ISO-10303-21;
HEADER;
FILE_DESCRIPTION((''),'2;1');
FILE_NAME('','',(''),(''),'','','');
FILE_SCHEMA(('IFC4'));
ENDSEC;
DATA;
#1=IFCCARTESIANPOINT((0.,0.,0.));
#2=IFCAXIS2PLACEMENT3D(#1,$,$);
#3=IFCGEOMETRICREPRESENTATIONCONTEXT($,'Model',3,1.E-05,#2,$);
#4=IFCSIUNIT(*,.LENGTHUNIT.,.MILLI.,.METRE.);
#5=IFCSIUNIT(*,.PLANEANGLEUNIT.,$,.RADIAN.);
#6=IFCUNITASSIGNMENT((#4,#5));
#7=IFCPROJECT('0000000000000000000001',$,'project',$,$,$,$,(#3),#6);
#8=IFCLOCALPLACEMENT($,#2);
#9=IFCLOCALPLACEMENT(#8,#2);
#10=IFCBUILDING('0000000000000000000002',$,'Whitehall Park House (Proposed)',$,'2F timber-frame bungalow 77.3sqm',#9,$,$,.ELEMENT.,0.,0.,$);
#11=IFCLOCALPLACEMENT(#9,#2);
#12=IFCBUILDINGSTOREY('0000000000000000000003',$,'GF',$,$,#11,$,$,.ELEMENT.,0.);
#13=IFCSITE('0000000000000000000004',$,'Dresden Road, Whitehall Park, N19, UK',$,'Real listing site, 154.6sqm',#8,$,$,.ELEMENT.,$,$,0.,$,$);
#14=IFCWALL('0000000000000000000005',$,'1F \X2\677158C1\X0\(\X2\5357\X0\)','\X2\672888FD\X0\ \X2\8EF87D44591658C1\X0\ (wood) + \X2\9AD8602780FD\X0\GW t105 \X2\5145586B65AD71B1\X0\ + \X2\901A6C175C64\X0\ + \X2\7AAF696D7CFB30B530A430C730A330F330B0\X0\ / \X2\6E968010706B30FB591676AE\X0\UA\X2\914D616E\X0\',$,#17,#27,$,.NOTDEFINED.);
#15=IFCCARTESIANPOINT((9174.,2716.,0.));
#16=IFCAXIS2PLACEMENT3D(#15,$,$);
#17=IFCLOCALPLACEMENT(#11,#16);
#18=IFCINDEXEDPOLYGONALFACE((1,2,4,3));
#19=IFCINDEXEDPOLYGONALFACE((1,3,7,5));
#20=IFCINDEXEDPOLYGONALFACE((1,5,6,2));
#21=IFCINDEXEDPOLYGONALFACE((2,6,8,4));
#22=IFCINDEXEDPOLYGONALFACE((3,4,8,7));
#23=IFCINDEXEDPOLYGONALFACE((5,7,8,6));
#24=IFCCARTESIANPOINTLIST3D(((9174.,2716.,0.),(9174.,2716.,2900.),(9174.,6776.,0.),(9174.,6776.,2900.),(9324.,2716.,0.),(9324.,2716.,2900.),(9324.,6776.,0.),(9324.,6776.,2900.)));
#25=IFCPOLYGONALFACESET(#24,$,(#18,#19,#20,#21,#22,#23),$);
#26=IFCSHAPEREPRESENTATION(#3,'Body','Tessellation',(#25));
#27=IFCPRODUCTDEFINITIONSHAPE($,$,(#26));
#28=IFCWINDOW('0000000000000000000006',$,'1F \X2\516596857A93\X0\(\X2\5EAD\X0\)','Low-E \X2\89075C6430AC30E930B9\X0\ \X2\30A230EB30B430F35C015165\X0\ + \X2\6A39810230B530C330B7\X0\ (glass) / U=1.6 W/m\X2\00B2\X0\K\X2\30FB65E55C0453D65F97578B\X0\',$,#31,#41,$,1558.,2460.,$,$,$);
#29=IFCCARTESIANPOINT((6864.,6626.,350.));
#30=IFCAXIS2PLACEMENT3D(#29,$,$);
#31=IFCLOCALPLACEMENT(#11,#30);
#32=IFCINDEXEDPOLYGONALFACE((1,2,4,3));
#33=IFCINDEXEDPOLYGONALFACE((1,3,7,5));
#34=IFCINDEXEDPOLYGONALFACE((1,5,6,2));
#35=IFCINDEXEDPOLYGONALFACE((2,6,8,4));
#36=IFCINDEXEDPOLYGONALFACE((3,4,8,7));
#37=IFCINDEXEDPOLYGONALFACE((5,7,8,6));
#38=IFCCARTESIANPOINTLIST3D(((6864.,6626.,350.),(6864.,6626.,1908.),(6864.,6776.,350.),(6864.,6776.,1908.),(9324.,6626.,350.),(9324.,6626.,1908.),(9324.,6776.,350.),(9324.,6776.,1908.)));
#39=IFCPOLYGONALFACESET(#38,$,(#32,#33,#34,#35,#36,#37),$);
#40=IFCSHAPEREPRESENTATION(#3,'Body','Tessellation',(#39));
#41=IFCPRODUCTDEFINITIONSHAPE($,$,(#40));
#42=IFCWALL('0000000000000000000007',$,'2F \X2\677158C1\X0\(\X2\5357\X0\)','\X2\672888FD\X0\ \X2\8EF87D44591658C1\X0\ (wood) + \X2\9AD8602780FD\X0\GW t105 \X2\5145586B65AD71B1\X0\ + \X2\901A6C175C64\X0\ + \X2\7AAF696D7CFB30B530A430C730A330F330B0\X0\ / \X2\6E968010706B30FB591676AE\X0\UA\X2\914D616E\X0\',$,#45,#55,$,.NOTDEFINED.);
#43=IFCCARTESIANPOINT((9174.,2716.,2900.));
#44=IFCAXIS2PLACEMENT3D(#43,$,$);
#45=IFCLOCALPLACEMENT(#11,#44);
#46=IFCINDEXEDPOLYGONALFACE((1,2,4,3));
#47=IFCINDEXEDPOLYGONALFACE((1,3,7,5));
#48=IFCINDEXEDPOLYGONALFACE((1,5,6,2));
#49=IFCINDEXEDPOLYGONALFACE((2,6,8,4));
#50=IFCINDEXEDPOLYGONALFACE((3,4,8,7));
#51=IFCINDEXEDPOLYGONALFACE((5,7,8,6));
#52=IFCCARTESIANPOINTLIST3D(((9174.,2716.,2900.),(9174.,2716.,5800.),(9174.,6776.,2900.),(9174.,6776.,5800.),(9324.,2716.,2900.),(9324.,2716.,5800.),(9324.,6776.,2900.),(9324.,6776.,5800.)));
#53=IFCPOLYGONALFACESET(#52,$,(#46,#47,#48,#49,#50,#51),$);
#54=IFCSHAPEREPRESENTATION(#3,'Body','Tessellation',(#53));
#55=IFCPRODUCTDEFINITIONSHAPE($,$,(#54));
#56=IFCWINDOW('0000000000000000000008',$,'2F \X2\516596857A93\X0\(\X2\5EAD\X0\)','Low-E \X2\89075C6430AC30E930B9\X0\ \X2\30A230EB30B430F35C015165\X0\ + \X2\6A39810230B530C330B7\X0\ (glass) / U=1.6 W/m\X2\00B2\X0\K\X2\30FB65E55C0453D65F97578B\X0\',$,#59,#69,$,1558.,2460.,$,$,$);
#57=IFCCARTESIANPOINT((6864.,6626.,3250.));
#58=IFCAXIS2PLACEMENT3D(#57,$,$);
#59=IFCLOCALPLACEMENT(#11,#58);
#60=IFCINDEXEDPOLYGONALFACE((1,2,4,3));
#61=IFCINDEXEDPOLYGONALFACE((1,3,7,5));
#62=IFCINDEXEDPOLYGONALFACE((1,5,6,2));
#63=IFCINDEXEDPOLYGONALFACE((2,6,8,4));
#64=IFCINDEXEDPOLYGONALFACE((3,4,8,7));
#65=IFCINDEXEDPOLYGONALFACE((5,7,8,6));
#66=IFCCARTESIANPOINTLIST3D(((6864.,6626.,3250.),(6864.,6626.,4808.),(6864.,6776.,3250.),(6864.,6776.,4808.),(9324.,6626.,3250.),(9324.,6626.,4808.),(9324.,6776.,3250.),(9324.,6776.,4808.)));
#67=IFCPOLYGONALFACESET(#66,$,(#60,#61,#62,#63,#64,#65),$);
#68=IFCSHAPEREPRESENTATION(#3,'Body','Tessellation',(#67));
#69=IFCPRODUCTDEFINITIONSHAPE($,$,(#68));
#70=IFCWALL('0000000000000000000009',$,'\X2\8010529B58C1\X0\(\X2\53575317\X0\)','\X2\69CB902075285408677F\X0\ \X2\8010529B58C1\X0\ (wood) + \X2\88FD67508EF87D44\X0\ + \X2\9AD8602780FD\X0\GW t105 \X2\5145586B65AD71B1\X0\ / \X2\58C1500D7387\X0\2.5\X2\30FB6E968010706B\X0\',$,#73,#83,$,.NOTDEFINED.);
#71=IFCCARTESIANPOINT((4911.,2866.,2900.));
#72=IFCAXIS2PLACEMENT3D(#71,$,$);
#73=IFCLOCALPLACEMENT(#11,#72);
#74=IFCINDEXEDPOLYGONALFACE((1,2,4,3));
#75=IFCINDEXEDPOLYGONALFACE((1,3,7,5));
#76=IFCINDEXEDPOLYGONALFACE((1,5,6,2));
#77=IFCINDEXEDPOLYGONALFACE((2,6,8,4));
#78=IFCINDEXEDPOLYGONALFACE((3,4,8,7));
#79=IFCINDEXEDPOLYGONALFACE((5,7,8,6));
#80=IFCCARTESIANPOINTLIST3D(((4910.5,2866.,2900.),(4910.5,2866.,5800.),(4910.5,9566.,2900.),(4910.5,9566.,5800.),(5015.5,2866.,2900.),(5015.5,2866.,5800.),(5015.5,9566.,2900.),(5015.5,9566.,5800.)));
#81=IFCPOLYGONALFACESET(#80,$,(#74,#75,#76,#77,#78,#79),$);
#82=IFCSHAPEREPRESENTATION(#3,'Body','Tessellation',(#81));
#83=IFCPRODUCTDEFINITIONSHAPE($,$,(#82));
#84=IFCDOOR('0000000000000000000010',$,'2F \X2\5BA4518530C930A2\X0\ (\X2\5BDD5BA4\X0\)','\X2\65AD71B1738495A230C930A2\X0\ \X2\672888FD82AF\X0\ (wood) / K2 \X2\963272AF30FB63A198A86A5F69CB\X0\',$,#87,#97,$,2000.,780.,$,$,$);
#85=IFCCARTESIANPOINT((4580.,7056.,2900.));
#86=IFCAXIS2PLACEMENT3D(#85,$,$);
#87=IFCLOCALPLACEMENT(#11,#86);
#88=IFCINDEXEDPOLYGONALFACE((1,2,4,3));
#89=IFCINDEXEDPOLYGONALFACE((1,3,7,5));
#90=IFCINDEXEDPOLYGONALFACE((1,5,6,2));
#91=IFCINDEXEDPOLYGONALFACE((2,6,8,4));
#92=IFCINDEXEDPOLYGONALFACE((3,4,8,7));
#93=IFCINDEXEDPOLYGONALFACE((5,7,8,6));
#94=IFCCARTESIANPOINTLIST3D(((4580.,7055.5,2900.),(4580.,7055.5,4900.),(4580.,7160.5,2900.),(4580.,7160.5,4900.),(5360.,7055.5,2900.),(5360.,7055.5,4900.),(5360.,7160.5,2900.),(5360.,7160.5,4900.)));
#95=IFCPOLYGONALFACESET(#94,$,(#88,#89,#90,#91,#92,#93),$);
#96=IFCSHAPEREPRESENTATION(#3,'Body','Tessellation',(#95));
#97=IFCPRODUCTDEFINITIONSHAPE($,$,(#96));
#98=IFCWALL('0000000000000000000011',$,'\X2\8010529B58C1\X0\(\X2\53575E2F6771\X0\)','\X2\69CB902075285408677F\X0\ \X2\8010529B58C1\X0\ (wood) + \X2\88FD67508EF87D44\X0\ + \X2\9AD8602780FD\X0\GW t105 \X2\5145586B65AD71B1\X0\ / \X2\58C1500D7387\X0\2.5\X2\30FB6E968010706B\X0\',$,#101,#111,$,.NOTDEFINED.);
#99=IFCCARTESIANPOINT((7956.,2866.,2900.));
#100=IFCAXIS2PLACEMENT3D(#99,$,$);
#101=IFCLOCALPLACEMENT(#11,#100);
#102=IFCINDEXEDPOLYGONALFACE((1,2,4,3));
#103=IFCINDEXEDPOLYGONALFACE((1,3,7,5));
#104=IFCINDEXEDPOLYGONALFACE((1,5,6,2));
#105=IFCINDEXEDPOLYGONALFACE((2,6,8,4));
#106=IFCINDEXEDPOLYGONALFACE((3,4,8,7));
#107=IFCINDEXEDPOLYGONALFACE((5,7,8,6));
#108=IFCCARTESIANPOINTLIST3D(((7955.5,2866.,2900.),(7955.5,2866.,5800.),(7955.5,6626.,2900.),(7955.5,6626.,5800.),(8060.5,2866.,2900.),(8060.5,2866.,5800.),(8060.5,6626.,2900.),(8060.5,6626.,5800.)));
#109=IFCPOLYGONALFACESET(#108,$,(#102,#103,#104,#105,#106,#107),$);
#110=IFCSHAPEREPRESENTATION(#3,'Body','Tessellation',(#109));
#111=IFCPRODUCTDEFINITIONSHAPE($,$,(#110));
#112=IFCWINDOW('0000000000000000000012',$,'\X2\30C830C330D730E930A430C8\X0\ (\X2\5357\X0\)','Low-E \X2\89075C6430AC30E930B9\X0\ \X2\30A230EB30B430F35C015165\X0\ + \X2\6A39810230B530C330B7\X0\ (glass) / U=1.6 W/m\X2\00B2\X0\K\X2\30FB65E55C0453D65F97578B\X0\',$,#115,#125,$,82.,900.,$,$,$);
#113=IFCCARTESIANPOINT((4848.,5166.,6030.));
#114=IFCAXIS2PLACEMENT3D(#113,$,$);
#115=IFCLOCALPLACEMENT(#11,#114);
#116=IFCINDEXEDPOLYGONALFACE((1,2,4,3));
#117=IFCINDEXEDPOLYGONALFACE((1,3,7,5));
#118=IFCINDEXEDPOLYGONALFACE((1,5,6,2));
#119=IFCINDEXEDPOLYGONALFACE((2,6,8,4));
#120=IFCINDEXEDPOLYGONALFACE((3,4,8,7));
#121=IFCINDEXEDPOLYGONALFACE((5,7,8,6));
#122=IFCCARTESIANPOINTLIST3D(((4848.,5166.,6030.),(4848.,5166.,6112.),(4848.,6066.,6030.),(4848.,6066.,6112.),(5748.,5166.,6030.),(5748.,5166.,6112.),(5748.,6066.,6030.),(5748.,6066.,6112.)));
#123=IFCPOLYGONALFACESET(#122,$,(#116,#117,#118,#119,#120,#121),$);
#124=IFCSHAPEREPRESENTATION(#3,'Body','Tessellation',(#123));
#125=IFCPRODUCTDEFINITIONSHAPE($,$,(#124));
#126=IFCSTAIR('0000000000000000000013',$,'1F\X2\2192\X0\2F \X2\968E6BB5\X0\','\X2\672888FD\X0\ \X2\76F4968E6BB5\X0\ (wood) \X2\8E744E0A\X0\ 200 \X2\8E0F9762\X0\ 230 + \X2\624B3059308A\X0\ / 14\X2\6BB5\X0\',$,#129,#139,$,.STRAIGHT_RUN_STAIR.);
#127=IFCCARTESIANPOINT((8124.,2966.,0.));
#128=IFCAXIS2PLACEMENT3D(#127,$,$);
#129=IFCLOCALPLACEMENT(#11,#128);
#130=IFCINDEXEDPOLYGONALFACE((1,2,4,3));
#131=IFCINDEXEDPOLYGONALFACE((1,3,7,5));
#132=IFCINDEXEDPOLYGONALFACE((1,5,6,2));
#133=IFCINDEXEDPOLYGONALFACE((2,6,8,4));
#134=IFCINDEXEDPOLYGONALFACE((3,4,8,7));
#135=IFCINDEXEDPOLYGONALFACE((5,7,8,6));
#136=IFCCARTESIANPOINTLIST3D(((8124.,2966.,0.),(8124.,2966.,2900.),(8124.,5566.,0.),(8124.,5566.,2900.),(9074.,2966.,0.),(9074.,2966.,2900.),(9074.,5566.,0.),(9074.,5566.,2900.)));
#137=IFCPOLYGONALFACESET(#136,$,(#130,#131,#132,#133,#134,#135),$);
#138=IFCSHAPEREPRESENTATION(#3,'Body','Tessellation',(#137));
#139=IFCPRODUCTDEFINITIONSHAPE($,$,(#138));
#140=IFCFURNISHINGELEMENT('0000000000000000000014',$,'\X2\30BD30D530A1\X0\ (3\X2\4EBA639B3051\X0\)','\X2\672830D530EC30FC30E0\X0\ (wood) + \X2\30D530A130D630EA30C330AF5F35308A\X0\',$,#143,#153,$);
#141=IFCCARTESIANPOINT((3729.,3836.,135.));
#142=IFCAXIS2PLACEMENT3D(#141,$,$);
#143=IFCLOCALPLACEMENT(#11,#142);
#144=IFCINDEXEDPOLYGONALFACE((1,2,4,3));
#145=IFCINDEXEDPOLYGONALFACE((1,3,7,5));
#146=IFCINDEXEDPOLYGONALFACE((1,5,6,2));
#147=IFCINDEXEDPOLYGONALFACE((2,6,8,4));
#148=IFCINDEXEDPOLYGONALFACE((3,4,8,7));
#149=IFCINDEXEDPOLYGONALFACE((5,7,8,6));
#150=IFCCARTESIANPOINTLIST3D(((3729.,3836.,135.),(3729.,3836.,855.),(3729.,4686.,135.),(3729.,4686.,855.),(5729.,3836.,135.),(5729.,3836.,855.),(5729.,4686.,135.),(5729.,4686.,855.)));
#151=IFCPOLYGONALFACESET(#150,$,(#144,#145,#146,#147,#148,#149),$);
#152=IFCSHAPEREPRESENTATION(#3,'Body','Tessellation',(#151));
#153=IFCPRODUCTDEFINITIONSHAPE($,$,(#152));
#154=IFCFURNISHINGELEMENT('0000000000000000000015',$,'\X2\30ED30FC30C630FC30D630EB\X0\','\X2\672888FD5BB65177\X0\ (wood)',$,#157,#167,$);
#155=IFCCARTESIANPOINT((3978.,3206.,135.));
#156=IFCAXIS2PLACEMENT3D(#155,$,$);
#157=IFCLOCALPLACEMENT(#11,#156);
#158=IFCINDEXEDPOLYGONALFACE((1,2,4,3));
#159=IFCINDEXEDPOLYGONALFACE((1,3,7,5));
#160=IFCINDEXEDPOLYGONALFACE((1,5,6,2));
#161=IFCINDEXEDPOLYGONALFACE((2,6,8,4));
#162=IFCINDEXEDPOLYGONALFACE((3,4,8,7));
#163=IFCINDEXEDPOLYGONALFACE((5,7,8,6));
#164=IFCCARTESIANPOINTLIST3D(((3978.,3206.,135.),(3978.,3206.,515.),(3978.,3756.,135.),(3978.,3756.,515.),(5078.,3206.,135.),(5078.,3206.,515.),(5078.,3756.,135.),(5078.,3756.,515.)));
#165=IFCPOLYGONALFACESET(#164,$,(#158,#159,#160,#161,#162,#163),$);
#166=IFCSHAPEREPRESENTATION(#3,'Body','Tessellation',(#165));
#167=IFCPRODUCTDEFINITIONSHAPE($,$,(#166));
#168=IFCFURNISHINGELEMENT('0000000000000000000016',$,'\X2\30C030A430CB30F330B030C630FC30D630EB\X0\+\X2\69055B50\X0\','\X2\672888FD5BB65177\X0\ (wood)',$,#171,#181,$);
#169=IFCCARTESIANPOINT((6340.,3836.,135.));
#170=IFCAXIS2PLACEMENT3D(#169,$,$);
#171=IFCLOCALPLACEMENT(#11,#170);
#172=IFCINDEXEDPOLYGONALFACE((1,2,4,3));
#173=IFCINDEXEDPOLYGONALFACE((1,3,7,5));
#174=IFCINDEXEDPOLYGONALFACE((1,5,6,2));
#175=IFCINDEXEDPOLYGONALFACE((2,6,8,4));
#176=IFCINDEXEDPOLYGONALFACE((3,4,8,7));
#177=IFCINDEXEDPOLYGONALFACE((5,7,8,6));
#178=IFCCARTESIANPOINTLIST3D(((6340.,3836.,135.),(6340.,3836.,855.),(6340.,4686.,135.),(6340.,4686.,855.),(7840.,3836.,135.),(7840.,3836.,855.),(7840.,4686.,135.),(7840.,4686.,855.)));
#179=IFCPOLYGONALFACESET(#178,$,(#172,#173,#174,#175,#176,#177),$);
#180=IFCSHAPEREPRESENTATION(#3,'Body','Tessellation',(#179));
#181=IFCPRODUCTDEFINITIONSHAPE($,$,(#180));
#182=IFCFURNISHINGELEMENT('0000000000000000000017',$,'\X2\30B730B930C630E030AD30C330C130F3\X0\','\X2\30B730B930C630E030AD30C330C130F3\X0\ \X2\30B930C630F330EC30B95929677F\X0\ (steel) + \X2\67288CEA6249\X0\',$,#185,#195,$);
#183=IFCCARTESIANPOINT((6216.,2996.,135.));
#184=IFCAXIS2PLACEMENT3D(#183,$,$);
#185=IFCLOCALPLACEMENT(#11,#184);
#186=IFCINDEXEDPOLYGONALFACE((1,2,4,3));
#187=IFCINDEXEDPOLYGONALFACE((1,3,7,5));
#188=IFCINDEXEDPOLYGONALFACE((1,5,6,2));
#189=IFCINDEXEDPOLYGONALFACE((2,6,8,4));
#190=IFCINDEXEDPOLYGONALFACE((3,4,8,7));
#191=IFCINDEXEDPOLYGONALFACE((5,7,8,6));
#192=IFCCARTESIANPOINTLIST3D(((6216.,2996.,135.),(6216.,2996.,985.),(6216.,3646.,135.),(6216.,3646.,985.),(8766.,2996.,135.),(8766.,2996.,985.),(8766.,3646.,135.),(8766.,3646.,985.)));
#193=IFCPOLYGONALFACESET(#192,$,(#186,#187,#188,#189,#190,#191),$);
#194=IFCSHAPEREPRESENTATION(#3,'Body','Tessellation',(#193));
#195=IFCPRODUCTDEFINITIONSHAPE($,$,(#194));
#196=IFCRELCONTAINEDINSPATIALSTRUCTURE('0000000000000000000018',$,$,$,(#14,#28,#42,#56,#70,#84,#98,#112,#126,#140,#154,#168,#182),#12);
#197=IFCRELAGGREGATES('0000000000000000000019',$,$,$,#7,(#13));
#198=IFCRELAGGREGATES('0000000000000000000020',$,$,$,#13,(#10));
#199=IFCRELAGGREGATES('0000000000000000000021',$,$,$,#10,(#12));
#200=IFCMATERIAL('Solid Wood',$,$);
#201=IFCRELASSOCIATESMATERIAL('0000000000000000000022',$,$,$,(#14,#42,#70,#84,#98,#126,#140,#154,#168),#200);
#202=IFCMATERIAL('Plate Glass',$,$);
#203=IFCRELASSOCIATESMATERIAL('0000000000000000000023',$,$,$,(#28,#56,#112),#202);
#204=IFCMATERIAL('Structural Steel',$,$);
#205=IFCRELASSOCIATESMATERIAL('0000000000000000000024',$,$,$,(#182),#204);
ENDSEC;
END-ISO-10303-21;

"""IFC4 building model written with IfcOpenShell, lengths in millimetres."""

from ifc_helpers import new_model, si_unit, frame, frame_2d, origin, place, context, project, spatial, rectangle, extrude, material, element, fill, save


model = new_model("IFC4")

# Units and contexts
model_context = context("Model", 3, precision=1e-05, world=origin())
ifc_project = project(units=[si_unit("LENGTHUNIT", "METRE", prefix="MILLI"), si_unit("PLANEANGLEUNIT", "RADIAN")], contexts=[model_context])

# Site, building, storey
site_placement = place(None, origin())
site = spatial("IfcSite", under=ifc_project, at=site_placement, Name="Dresden Road, Whitehall Park, N19, UK", ObjectType="Real listing site, 154.6sqm", CompositionType="ELEMENT", RefElevation=0.0)
building_placement = place(site_placement, origin())
building = spatial("IfcBuilding", under=site, at=building_placement, Name="Whitehall Park House (Proposed)", ObjectType="2F timber-frame bungalow 77.3sqm", CompositionType="ELEMENT", ElevationOfRefHeight=0.0, ElevationOfTerrain=0.0)
storey_placement = place(building_placement, origin())
storey = spatial("IfcBuildingStorey", under=building, at=storey_placement, Name="GF", CompositionType="ELEMENT", Elevation=0.0)

# Wall, opening, window
ifc_material_1 = material(Name="Solid Wood")
wall_1_placement = place(storey_placement, frame((9174.0, 2716.0, 0.0)))
wall_1 = element("IfcWall", 1, at=wall_1_placement, inside=storey, material=ifc_material_1, Name="1F 東壁(南)", Description="木製 軸組外壁 (wood) + 高性能GW t105 充填断熱 + 通気層 + 窯業系サイディング / 準耐火・外皮UA配慮", PredefinedType="NOTDEFINED", context=model_context, shape_type="SweptSolid", body=[
    extrude(rectangle(XDim=150.0, YDim=4060.0, at=frame_2d((75.0, 2030.0))), frame((9174.0, 2716.0, 0.0)), (0.0, 0.0, 1.0), 2900.0),
])
opening_1_placement = place(storey_placement, frame((6864.0, 6626.0, 350.0)))
opening_1 = element("IfcOpeningElement", 2, at=opening_1_placement, cuts=wall_1, PredefinedType="NOTDEFINED", context=model_context, shape_type="SweptSolid", body=[
    extrude(rectangle(XDim=2460.0, YDim=150.0, at=frame_2d((1230.0, 75.0))), frame((6864.0, 6626.0, 350.0)), (0.0, 0.0, 1.0), 1558.0),
])
ifc_material_2 = material(Name="Plate Glass")
window_1_placement = place(storey_placement, frame((6864.0, 6626.0, 350.0)))
window_1 = element("IfcWindow", 3, at=window_1_placement, inside=storey, material=ifc_material_2, Name="1F 入隅窓(庭)", Description="Low-E 複層ガラス アルゴン封入 + 樹脂サッシ (glass) / U=1.6 W/m²K・日射取得型", OverallHeight=1558.0, OverallWidth=2460.0, context=model_context, shape_type="SweptSolid", body=[
    extrude(rectangle(XDim=2460.0, YDim=150.0, at=frame_2d((1230.0, 75.0))), frame((6864.0, 6626.0, 350.0)), (0.0, 0.0, 1.0), 1558.0),
])
fill(opening_1, window_1)

# Wall, opening, window
wall_2_placement = place(storey_placement, frame((9174.0, 2716.0, 2900.0)))
wall_2 = element("IfcWall", 4, at=wall_2_placement, inside=storey, material=ifc_material_1, Name="2F 東壁(南)", Description="木製 軸組外壁 (wood) + 高性能GW t105 充填断熱 + 通気層 + 窯業系サイディング / 準耐火・外皮UA配慮", PredefinedType="NOTDEFINED", context=model_context, shape_type="SweptSolid", body=[
    extrude(rectangle(XDim=150.0, YDim=4060.0, at=frame_2d((75.0, 2030.0))), frame((9174.0, 2716.0, 2900.0)), (0.0, 0.0, 1.0), 2900.0),
])
opening_2_placement = place(storey_placement, frame((6864.0, 6626.0, 3250.0)))
opening_2 = element("IfcOpeningElement", 5, at=opening_2_placement, cuts=wall_2, PredefinedType="NOTDEFINED", context=model_context, shape_type="SweptSolid", body=[
    extrude(rectangle(XDim=2460.0, YDim=150.0, at=frame_2d((1230.0, 75.0))), frame((6864.0, 6626.0, 3250.0)), (0.0, 0.0, 1.0), 1558.0),
])
window_2_placement = place(storey_placement, frame((6864.0, 6626.0, 3250.0)))
window_2 = element("IfcWindow", 6, at=window_2_placement, inside=storey, material=ifc_material_2, Name="2F 入隅窓(庭)", Description="Low-E 複層ガラス アルゴン封入 + 樹脂サッシ (glass) / U=1.6 W/m²K・日射取得型", OverallHeight=1558.0, OverallWidth=2460.0, context=model_context, shape_type="SweptSolid", body=[
    extrude(rectangle(XDim=2460.0, YDim=150.0, at=frame_2d((1230.0, 75.0))), frame((6864.0, 6626.0, 3250.0)), (0.0, 0.0, 1.0), 1558.0),
])
fill(opening_2, window_2)

# Wall, opening, door
wall_3_placement = place(storey_placement, frame((4911.0, 2866.0, 2900.0)))
wall_3 = element("IfcWall", 7, at=wall_3_placement, inside=storey, material=ifc_material_1, Name="耐力壁(南北)", Description="構造用合板 耐力壁 (wood) + 製材軸組 + 高性能GW t105 充填断熱 / 壁倍率2.5・準耐火", PredefinedType="NOTDEFINED", context=model_context, shape_type="SweptSolid", body=[
    extrude(rectangle(XDim=105.0, YDim=6700.0, at=frame_2d((52.0, 3350.0))), frame((4911.0, 2866.0, 2900.0)), (0.0, 0.0, 1.0), 2900.0),
])
opening_3_placement = place(storey_placement, frame((4580.0, 7056.0, 2900.0)))
opening_3 = element("IfcOpeningElement", 8, at=opening_3_placement, cuts=wall_3, PredefinedType="NOTDEFINED", context=model_context, shape_type="SweptSolid", body=[
    extrude(rectangle(XDim=780.0, YDim=105.0, at=frame_2d((390.0, 52.0))), frame((4580.0, 7056.0, 2900.0)), (0.0, 0.0, 1.0), 2000.0),
])
door_1_placement = place(storey_placement, frame((4580.0, 7056.0, 2900.0)))
door_1 = element("IfcDoor", 9, at=door_1_placement, inside=storey, material=ifc_material_1, Name="2F 室内ドア (寝室)", Description="断熱玄関ドア 木製芯 (wood) / K2 防犯・採風機構", OverallHeight=2000.0, OverallWidth=780.0, context=model_context, shape_type="SweptSolid", body=[
    extrude(rectangle(XDim=780.0, YDim=105.0, at=frame_2d((390.0, 52.0))), frame((4580.0, 7056.0, 2900.0)), (0.0, 0.0, 1.0), 2000.0),
])
fill(opening_3, door_1)

# Wall
wall_4_placement = place(storey_placement, frame((7956.0, 2866.0, 2900.0)))
element("IfcWall", 10, at=wall_4_placement, inside=storey, material=ifc_material_1, Name="耐力壁(南帯東)", Description="構造用合板 耐力壁 (wood) + 製材軸組 + 高性能GW t105 充填断熱 / 壁倍率2.5・準耐火", PredefinedType="NOTDEFINED", context=model_context, shape_type="SweptSolid", body=[
    extrude(rectangle(XDim=105.0, YDim=3760.0, at=frame_2d((52.0, 1880.0))), frame((7956.0, 2866.0, 2900.0)), (0.0, 0.0, 1.0), 2900.0),
])

# Window
window_3_placement = place(storey_placement, frame((4848.0, 5166.0, 6030.0)))
element("IfcWindow", 11, at=window_3_placement, inside=storey, material=ifc_material_2, Name="トップライト (南)", Description="Low-E 複層ガラス アルゴン封入 + 樹脂サッシ (glass) / U=1.6 W/m²K・日射取得型", OverallHeight=82.0, OverallWidth=900.0, context=model_context, shape_type="SweptSolid", body=[
    extrude(rectangle(XDim=900.0, YDim=900.0, at=frame_2d((450.0, 450.0))), frame((4848.0, 5166.0, 6030.0)), (0.0, 0.0, 1.0), 82.0),
])

# Stair
stair_placement = place(storey_placement, frame((8124.0, 2966.0, 0.0)))
element("IfcStair", 12, at=stair_placement, inside=storey, material=ifc_material_1, Name="1F→2F 階段", Description="木製 直階段 (wood) 蹴上 200 踏面 230 + 手すり / 14段", PredefinedType="STRAIGHT_RUN_STAIR", context=model_context, shape_type="SweptSolid", body=[
    extrude(rectangle(XDim=950.0, YDim=2600.0, at=frame_2d((475.0, 1300.0))), frame((8124.0, 2966.0, 0.0)), (0.0, 0.0, 1.0), 2900.0),
])

# Furnishing elements
furnishing_1_placement = place(storey_placement, frame((3729.0, 3836.0, 135.0)))
element("IfcFurnishingElement", 13, at=furnishing_1_placement, inside=storey, material=ifc_material_1, Name="ソファ (3人掛け)", Description="木フレーム (wood) + ファブリック張り", context=model_context, shape_type="SweptSolid", body=[
    extrude(rectangle(XDim=2000.0, YDim=850.0, at=frame_2d((1000.0, 425.0))), frame((3729.0, 3836.0, 135.0)), (0.0, 0.0, 1.0), 720.0),
])
furnishing_2_placement = place(storey_placement, frame((3978.0, 3206.0, 135.0)))
element("IfcFurnishingElement", 14, at=furnishing_2_placement, inside=storey, material=ifc_material_1, Name="ローテーブル", Description="木製家具 (wood)", context=model_context, shape_type="SweptSolid", body=[
    extrude(rectangle(XDim=1100.0, YDim=550.0, at=frame_2d((550.0, 275.0))), frame((3978.0, 3206.0, 135.0)), (0.0, 0.0, 1.0), 380.0),
])
furnishing_3_placement = place(storey_placement, frame((6340.0, 3836.0, 135.0)))
element("IfcFurnishingElement", 15, at=furnishing_3_placement, inside=storey, material=ifc_material_1, Name="ダイニングテーブル+椅子", Description="木製家具 (wood)", context=model_context, shape_type="SweptSolid", body=[
    extrude(rectangle(XDim=1500.0, YDim=850.0, at=frame_2d((750.0, 425.0))), frame((6340.0, 3836.0, 135.0)), (0.0, 0.0, 1.0), 720.0),
])
ifc_material_3 = material(Name="Structural Steel")
furnishing_4_placement = place(storey_placement, frame((6216.0, 2996.0, 135.0)))
element("IfcFurnishingElement", 16, at=furnishing_4_placement, inside=storey, material=ifc_material_3, Name="システムキッチン", Description="システムキッチン ステンレス天板 (steel) + 木質扉", context=model_context, shape_type="SweptSolid", body=[
    extrude(rectangle(XDim=2550.0, YDim=650.0, at=frame_2d((1275.0, 325.0))), frame((6216.0, 2996.0, 135.0)), (0.0, 0.0, 1.0), 850.0),
])

save(model, "model.ifc")
